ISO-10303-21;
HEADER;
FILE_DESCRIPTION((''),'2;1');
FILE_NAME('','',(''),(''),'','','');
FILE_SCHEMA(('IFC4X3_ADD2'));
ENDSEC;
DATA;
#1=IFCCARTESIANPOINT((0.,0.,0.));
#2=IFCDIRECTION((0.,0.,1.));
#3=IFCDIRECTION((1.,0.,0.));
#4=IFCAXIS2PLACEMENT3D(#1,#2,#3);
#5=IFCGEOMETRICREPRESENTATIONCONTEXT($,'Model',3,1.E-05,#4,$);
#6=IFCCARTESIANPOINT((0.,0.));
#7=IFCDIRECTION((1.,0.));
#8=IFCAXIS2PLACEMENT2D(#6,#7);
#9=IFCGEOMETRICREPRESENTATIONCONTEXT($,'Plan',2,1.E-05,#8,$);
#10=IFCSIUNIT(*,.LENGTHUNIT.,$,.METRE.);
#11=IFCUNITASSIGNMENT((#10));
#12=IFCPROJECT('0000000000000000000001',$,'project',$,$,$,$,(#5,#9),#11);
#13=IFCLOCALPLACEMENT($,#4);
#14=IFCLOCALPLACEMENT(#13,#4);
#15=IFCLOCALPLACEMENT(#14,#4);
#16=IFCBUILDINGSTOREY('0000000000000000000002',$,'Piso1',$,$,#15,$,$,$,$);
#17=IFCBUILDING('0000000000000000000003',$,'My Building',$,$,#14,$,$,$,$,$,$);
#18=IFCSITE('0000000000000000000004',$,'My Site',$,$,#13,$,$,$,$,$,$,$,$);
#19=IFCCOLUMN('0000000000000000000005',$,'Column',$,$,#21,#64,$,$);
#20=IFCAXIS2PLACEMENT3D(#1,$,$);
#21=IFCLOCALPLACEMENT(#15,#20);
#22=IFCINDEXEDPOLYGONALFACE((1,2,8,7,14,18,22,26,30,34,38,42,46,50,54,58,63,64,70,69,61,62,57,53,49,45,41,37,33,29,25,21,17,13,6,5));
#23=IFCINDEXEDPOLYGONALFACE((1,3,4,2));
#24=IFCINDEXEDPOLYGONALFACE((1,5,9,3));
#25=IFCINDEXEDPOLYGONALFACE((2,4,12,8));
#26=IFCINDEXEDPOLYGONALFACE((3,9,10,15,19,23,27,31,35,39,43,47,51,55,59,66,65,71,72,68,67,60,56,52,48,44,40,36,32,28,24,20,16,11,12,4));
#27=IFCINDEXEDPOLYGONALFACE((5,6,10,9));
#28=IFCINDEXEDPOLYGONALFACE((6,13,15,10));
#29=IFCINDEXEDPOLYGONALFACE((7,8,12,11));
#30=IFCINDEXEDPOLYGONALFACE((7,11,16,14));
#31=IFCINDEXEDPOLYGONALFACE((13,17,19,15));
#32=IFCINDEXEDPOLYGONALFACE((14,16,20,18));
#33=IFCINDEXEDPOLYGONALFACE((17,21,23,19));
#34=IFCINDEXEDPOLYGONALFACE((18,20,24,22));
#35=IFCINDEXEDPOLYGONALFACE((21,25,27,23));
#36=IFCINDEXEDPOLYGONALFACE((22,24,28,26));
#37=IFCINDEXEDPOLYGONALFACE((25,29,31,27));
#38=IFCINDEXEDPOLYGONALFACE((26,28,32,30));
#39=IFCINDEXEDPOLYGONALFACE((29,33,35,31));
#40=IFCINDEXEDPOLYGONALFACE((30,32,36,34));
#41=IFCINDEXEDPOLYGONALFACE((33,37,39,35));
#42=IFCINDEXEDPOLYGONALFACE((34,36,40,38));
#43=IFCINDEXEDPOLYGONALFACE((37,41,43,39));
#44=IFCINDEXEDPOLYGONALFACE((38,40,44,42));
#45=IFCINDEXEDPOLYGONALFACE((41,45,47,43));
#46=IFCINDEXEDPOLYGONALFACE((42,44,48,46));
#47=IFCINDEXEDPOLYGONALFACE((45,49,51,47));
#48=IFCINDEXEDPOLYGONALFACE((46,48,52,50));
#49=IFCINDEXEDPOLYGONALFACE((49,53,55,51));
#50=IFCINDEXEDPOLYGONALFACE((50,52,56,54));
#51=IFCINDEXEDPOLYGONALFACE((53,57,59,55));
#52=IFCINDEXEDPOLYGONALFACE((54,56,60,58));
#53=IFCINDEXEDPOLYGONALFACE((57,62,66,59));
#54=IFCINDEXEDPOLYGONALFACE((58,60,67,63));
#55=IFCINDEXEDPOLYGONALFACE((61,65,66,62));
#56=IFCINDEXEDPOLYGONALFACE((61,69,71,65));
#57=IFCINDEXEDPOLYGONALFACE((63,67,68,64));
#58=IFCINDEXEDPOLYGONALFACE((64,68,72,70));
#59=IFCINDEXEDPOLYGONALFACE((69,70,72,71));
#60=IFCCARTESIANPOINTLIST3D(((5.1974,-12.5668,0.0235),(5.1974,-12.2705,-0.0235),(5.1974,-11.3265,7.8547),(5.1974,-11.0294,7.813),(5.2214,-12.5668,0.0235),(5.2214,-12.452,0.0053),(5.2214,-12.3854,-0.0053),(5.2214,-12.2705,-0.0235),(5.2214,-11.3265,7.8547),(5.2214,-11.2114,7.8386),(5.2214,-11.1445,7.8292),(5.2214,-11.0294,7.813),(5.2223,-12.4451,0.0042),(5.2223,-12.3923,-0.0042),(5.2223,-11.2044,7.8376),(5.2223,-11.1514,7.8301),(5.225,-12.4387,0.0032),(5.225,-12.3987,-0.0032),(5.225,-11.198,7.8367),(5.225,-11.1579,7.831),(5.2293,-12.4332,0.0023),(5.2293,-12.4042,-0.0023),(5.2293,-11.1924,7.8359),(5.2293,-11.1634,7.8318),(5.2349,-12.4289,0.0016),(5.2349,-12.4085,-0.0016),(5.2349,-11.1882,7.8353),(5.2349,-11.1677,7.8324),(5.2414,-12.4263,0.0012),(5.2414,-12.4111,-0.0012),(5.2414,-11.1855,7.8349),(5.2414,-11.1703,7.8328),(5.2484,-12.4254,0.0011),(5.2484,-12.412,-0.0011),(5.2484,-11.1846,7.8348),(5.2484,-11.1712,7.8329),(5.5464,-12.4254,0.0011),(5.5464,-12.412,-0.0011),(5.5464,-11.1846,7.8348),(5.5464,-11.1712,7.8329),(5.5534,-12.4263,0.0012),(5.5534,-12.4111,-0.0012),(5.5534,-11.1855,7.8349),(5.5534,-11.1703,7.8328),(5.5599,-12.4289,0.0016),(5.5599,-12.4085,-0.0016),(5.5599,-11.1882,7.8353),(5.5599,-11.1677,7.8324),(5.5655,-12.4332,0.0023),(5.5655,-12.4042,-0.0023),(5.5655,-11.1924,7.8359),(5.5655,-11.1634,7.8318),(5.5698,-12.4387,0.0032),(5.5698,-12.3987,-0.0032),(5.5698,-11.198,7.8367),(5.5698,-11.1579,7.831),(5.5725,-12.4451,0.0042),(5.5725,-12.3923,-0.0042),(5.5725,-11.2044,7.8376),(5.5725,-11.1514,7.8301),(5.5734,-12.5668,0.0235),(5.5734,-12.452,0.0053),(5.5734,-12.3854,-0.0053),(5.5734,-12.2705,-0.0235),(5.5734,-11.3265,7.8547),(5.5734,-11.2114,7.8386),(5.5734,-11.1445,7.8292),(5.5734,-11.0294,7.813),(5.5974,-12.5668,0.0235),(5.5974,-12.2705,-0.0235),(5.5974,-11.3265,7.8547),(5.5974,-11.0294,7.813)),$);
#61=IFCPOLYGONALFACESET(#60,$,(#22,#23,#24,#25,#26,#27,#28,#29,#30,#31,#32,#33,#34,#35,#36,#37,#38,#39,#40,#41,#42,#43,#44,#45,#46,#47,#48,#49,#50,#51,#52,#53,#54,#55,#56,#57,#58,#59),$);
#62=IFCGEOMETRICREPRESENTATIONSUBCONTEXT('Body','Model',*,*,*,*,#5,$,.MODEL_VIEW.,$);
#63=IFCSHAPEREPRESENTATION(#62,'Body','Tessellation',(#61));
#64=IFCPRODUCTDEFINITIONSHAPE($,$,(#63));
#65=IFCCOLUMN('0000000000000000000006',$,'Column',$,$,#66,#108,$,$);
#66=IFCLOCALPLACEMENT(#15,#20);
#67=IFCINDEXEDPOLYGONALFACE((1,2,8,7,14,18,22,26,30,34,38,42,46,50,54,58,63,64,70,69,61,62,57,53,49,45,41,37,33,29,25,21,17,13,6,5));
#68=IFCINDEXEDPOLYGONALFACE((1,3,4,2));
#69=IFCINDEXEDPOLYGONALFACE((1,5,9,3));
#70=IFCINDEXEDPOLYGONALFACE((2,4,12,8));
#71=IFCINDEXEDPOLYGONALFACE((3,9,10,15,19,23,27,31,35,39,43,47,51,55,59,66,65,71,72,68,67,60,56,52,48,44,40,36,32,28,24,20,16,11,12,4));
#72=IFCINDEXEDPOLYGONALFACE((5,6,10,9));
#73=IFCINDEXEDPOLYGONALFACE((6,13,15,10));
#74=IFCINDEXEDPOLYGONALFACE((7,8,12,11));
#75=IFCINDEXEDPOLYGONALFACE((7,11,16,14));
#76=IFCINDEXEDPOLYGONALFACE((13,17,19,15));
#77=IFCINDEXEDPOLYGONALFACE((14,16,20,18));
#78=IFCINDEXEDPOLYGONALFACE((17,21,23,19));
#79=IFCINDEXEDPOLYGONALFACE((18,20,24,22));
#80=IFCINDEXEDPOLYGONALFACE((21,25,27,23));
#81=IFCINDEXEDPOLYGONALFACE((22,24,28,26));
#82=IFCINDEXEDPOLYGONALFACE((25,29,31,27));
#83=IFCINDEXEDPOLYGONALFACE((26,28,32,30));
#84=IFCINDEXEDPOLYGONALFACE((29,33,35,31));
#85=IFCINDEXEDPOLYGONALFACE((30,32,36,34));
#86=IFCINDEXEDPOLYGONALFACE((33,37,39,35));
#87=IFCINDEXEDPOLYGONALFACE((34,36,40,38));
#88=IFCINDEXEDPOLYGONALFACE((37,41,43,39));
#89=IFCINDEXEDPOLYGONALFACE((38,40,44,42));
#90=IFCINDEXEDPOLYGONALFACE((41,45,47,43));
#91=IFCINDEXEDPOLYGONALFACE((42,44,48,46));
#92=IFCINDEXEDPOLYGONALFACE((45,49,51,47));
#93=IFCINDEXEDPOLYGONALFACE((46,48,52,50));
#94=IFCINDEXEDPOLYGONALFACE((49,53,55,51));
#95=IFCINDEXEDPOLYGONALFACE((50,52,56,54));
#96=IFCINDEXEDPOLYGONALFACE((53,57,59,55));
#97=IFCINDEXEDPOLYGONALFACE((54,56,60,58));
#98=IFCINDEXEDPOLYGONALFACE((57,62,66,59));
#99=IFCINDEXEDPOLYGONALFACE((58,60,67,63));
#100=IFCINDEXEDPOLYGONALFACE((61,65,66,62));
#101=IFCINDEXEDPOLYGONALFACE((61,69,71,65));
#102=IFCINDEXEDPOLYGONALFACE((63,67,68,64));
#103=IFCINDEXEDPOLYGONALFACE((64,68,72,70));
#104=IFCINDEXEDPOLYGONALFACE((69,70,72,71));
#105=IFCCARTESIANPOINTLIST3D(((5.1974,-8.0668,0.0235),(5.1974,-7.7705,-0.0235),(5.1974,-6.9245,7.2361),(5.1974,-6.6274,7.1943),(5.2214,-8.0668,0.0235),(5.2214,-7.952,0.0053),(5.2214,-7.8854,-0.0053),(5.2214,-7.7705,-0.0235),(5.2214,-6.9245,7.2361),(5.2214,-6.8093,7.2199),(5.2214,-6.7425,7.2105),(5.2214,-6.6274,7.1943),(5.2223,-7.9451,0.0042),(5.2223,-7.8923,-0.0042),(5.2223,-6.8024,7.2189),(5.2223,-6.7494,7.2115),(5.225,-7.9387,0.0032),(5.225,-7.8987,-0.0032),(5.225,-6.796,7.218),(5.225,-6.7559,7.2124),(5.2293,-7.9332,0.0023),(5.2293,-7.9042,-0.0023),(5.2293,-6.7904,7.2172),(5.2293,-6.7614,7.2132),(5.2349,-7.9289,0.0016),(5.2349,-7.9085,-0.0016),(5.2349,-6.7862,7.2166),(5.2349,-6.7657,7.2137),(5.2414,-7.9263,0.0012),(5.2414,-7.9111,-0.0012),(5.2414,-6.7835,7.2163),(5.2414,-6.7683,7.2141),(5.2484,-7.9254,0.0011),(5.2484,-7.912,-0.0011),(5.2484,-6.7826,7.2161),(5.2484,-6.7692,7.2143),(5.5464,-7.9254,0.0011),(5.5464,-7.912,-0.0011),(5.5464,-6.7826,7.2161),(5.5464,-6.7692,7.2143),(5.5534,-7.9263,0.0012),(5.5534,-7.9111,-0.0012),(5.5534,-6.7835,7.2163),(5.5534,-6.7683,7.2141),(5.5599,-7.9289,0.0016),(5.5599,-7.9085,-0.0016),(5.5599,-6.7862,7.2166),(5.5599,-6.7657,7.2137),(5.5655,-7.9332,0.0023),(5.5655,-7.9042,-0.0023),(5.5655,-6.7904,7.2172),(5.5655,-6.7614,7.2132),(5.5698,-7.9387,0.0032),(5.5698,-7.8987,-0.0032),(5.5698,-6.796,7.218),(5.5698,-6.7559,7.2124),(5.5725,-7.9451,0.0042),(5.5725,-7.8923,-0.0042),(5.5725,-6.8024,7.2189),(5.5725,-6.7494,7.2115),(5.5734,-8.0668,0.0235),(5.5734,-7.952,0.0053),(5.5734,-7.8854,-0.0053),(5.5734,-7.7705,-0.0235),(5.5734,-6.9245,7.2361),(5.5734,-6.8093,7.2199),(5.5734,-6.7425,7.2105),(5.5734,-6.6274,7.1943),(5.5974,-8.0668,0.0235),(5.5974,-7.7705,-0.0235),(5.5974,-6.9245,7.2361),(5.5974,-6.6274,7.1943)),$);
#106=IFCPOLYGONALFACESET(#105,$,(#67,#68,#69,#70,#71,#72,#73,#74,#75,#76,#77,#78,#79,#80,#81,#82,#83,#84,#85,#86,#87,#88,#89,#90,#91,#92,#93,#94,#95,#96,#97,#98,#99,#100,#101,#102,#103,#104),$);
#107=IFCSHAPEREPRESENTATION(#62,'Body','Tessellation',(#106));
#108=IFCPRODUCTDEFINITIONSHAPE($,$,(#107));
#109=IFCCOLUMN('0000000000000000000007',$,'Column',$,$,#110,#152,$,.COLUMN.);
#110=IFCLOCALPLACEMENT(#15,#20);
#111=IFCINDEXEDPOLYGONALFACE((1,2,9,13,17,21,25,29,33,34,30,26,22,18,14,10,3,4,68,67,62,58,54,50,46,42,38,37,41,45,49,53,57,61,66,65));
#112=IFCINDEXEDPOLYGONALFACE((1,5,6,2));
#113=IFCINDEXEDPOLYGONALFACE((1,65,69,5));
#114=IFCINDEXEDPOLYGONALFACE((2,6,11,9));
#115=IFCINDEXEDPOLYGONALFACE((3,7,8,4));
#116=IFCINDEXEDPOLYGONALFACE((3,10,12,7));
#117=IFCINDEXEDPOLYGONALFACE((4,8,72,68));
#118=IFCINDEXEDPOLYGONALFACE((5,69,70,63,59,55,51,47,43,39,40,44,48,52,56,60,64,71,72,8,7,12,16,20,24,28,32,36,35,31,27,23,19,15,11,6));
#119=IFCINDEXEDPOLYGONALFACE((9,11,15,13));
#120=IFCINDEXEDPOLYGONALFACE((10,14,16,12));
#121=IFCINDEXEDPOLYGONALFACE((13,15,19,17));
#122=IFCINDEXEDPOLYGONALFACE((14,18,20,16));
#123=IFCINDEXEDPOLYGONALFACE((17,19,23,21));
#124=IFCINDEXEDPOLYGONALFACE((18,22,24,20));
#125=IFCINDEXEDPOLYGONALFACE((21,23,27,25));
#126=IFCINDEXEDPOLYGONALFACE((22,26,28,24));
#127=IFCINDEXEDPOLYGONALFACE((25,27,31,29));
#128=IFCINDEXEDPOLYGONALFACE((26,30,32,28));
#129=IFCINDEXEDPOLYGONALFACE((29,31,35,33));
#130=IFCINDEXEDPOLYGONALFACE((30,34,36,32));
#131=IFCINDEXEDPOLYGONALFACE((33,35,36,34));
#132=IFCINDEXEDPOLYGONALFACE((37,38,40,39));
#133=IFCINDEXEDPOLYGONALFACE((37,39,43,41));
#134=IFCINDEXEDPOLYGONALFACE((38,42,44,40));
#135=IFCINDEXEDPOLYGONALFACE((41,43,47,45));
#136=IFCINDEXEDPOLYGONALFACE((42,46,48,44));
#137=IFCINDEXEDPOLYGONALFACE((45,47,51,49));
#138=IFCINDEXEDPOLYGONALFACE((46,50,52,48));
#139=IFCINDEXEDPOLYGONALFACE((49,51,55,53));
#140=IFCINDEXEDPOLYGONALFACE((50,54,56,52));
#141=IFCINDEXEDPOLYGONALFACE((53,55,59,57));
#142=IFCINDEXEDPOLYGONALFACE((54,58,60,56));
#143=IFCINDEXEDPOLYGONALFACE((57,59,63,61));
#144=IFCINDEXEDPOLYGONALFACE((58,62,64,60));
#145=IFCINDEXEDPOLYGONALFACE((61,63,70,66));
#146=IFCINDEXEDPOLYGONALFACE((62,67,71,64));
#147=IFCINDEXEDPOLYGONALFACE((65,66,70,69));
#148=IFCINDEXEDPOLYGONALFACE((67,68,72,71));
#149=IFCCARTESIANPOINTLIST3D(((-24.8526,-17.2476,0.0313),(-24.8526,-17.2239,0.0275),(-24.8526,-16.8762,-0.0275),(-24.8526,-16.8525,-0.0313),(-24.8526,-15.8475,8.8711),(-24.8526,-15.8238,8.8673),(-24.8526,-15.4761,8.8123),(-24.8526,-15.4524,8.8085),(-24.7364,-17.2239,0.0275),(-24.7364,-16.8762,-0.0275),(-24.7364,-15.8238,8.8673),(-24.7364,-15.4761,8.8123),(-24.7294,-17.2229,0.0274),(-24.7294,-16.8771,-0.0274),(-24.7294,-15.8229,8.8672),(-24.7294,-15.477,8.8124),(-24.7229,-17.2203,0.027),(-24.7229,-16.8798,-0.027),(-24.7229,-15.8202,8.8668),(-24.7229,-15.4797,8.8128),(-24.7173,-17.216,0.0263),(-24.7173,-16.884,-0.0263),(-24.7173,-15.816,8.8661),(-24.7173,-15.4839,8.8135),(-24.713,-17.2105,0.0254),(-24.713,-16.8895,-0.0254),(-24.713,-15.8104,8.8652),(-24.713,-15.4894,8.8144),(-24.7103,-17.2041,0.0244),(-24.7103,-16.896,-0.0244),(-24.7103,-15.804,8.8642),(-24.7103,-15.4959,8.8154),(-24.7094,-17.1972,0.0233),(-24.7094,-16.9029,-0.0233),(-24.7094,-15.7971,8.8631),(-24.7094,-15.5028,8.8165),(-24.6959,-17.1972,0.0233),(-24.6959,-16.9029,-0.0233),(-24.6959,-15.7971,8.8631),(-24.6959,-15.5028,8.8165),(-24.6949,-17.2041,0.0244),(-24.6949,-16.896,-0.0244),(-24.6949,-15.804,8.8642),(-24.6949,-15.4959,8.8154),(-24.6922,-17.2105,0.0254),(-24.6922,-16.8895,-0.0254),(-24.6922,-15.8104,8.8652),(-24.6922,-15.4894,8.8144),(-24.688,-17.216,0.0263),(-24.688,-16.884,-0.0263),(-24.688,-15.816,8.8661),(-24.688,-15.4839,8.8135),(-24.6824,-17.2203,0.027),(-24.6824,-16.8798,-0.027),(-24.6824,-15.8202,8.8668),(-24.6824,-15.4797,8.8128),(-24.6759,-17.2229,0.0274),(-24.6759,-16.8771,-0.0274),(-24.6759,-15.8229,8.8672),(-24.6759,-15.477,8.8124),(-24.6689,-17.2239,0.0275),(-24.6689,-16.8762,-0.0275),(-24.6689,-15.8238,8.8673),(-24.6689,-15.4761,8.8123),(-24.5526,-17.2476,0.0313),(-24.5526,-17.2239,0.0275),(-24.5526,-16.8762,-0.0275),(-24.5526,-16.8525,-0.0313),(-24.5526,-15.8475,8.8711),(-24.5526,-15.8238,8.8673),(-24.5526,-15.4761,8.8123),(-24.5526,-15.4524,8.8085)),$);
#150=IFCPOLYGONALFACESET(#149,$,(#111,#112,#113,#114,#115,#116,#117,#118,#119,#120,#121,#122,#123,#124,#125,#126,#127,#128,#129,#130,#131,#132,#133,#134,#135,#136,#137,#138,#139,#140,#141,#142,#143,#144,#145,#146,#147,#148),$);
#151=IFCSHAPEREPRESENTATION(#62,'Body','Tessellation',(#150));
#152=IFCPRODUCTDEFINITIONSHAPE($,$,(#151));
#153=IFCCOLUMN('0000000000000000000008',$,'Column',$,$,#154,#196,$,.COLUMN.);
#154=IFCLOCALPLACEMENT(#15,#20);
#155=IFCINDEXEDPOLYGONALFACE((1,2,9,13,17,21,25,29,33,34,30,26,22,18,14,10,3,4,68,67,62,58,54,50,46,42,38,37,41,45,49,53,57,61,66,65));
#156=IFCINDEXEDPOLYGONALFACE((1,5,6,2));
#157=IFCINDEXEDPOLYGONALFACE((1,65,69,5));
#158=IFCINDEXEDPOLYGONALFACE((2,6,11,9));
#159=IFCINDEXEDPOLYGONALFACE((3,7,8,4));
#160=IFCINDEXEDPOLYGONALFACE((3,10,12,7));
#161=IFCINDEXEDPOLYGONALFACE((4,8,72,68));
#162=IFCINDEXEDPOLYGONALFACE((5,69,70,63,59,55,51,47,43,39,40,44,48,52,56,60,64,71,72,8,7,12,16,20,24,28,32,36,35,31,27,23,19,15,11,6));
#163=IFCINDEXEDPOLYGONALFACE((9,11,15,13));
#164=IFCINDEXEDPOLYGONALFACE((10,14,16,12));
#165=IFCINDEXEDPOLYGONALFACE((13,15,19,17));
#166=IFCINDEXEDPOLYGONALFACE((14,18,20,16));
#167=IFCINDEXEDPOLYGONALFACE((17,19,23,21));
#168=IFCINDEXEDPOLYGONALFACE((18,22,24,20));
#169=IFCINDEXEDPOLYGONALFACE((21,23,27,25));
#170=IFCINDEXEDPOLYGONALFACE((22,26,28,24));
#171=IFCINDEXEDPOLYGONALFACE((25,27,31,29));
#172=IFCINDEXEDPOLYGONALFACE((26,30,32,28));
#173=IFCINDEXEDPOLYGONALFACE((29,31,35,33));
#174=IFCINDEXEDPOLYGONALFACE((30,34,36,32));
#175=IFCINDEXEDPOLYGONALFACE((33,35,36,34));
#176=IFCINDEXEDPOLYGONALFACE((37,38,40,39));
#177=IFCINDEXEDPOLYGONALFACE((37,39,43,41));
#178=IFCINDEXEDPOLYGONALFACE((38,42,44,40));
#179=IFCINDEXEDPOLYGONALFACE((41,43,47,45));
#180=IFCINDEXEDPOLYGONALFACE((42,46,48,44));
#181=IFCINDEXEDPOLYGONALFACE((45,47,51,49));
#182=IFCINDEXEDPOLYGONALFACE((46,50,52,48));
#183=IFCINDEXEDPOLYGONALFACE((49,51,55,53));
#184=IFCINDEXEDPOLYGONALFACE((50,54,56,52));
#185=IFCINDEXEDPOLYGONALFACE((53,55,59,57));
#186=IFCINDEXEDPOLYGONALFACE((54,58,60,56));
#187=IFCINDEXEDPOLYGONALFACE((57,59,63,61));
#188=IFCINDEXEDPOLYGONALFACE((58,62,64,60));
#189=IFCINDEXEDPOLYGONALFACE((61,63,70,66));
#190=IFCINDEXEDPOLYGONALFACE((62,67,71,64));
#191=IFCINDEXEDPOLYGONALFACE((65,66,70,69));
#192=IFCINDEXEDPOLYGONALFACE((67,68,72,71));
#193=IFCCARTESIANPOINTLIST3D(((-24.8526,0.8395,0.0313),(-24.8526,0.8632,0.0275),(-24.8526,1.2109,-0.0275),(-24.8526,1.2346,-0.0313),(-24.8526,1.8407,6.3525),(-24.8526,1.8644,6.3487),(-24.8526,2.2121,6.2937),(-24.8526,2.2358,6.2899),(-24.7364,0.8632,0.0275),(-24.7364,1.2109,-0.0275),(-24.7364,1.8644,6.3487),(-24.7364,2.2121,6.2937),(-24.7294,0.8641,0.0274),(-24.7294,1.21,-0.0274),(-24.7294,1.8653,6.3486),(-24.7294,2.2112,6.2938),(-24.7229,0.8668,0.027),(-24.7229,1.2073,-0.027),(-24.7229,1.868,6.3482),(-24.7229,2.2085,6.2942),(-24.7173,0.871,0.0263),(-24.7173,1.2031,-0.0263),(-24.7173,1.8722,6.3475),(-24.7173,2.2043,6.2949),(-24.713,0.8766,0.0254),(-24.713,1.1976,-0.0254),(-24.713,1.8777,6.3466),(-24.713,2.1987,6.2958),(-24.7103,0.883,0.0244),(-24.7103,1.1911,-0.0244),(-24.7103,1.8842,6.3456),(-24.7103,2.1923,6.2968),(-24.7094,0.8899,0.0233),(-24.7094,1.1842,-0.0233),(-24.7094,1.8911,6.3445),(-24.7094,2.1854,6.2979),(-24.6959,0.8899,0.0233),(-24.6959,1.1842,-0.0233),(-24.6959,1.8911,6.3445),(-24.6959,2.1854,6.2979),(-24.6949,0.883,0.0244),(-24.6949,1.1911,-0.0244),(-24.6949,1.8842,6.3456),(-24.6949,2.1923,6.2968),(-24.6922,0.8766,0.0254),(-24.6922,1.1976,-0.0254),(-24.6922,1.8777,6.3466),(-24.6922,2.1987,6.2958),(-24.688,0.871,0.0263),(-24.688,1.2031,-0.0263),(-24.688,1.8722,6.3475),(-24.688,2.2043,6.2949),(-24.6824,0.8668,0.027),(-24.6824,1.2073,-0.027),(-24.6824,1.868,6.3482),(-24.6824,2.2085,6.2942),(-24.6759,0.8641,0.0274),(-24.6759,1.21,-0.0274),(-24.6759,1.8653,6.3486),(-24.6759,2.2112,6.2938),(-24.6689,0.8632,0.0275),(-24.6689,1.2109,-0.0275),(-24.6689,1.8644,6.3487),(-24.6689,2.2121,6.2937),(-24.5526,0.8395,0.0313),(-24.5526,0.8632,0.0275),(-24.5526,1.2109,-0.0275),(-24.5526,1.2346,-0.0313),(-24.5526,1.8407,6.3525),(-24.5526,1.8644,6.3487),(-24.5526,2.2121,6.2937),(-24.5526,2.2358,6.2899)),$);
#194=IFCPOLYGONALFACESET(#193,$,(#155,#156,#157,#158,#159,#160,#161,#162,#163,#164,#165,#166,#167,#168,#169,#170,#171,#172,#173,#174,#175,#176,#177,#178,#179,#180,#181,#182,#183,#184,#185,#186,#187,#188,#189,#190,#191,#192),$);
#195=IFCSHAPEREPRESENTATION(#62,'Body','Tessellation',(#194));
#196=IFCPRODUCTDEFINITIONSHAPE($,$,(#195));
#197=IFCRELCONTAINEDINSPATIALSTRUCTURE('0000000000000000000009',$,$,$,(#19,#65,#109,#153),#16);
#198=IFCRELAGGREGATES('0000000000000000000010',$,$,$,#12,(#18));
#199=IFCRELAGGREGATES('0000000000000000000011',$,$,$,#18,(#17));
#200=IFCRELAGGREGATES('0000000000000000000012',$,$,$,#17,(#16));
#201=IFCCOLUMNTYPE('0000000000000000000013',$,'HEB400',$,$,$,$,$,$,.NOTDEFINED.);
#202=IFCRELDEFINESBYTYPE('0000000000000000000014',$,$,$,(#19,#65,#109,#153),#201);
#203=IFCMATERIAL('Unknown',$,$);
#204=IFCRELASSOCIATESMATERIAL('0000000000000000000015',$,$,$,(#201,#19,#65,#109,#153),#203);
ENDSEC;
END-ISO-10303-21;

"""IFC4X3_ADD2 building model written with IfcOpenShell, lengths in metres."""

from ifc_helpers import new_model, si_unit, frame, origin_with_axes, origin_2d_with_axis, place, context, subcontext, project, spatial, i_section, extrude, clip, halfspace, material, material_profile, profile_set, profile_usage, type_object, element, save


model = new_model("IFC4X3_ADD2")

# Units and contexts
model_context = context("Model", 3, precision=1e-05, world=origin_with_axes())
plan_context = context("Plan", 2, precision=1e-05, world=origin_2d_with_axis())
body_context_1 = subcontext(model_context, "Body", "Model", "MODEL_VIEW")
ifc_project = project(units=[si_unit("LENGTHUNIT", "METRE")], contexts=[model_context, plan_context])

# Site, building, storey
site_placement = place(None, origin_with_axes())
site = spatial("IfcSite", under=ifc_project, at=site_placement, Name="My Site")
building_placement = place(site_placement, origin_with_axes())
building = spatial("IfcBuilding", under=site, at=building_placement, Name="My Building")
storey_placement = place(building_placement, origin_with_axes())
storey = spatial("IfcBuildingStorey", under=building, at=storey_placement, Name="Piso1")

# Columns
ifc_material_1 = material(Name="Unknown")
ifc_material_profile_1 = material_profile(ifc_material_1, i_section(OverallWidth=0.3, OverallDepth=0.4, WebThickness=0.0135, FlangeThickness=0.024, FilletRadius=0.027))
ifc_profile_set_1 = profile_set([ifc_material_profile_1])
column_type_1 = type_object("IfcColumnType", Name="HEB400", PredefinedType="NOTDEFINED", material=ifc_profile_set_1)
ifc_profile_usage_1 = profile_usage(ifc_profile_set_1, cardinal=5)
column_1_placement = place(storey_placement, frame((5.3974, -12.4187, 0.0), z_axis=(0.0, 0.156434, 0.987688), x_axis=(0.0, 0.987688, -0.156434)))
element("IfcColumn", 1, at=column_1_placement, inside=storey, type_object=column_type_1, material=ifc_profile_usage_1, Name="Column", context=body_context_1, shape_type="Clipping", body=[
    clip(extrude(i_section(OverallWidth=0.3, OverallDepth=0.4, WebThickness=0.0135, FlangeThickness=0.024, FilletRadius=0.027), origin_with_axes(), (0.0, 0.0, 1.0), 8.3315), halfspace(frame((-4.6772, 0.11, 7.8499), z_axis=(-0.017453, 0.0, 0.999848), x_axis=(-0.000003, 1.0, 0.0)), False)),
])
ifc_profile_usage_2 = profile_usage(ifc_profile_set_1, cardinal=5)
column_2_placement = place(storey_placement, frame((5.3974, -7.9187, 0.0), z_axis=(0.0, 0.156434, 0.987688), x_axis=(0.0, 0.987688, -0.156434)))
element("IfcColumn", 2, at=column_2_placement, inside=storey, type_object=column_type_1, material=ifc_profile_usage_2, Name="Column", context=body_context_1, shape_type="Clipping", body=[
    clip(extrude(i_section(OverallWidth=0.3, OverallDepth=0.4, WebThickness=0.0135, FlangeThickness=0.024, FilletRadius=0.027), origin_with_axes(), (0.0, 0.0, 1.0), 7.7051), halfspace(frame((-9.1218, 0.11, 7.1459), z_axis=(-0.017453, 0.0, 0.999848), x_axis=(-0.000003, 1.0, 0.0)), False)),
])
ifc_profile_usage_3 = profile_usage(ifc_profile_set_1)
column_3_placement = place(storey_placement, frame((-24.7026, -17.05, 0.0), z_axis=(0.0, 0.156434, 0.987688), x_axis=(1.0, 0.0, 0.0)))
element("IfcColumn", 3, at=column_3_placement, inside=storey, type_object=column_type_1, material=ifc_profile_usage_3, Name="Column", PredefinedType="COLUMN", context=body_context_1, shape_type="SweptSolid", body=[
    extrude(i_section(OverallWidth=0.3, OverallDepth=0.4, WebThickness=0.0135, FlangeThickness=0.024, FilletRadius=0.027), origin_with_axes(), (0.0, 0.0, 1.0), 8.95),
])
ifc_profile_usage_4 = profile_usage(ifc_profile_set_1)
column_4_placement = place(storey_placement, frame((-24.7026, 1.0371, 0.0), z_axis=(0.0, 0.156434, 0.987688), x_axis=(1.0, 0.0, 0.0)))
element("IfcColumn", 4, at=column_4_placement, inside=storey, type_object=column_type_1, material=ifc_profile_usage_4, Name="Column", PredefinedType="COLUMN", context=body_context_1, shape_type="SweptSolid", body=[
    extrude(i_section(OverallWidth=0.3, OverallDepth=0.4, WebThickness=0.0135, FlangeThickness=0.024, FilletRadius=0.027), origin_with_axes(), (0.0, 0.0, 1.0), 6.4),
])

save(model, "model.ifc")
